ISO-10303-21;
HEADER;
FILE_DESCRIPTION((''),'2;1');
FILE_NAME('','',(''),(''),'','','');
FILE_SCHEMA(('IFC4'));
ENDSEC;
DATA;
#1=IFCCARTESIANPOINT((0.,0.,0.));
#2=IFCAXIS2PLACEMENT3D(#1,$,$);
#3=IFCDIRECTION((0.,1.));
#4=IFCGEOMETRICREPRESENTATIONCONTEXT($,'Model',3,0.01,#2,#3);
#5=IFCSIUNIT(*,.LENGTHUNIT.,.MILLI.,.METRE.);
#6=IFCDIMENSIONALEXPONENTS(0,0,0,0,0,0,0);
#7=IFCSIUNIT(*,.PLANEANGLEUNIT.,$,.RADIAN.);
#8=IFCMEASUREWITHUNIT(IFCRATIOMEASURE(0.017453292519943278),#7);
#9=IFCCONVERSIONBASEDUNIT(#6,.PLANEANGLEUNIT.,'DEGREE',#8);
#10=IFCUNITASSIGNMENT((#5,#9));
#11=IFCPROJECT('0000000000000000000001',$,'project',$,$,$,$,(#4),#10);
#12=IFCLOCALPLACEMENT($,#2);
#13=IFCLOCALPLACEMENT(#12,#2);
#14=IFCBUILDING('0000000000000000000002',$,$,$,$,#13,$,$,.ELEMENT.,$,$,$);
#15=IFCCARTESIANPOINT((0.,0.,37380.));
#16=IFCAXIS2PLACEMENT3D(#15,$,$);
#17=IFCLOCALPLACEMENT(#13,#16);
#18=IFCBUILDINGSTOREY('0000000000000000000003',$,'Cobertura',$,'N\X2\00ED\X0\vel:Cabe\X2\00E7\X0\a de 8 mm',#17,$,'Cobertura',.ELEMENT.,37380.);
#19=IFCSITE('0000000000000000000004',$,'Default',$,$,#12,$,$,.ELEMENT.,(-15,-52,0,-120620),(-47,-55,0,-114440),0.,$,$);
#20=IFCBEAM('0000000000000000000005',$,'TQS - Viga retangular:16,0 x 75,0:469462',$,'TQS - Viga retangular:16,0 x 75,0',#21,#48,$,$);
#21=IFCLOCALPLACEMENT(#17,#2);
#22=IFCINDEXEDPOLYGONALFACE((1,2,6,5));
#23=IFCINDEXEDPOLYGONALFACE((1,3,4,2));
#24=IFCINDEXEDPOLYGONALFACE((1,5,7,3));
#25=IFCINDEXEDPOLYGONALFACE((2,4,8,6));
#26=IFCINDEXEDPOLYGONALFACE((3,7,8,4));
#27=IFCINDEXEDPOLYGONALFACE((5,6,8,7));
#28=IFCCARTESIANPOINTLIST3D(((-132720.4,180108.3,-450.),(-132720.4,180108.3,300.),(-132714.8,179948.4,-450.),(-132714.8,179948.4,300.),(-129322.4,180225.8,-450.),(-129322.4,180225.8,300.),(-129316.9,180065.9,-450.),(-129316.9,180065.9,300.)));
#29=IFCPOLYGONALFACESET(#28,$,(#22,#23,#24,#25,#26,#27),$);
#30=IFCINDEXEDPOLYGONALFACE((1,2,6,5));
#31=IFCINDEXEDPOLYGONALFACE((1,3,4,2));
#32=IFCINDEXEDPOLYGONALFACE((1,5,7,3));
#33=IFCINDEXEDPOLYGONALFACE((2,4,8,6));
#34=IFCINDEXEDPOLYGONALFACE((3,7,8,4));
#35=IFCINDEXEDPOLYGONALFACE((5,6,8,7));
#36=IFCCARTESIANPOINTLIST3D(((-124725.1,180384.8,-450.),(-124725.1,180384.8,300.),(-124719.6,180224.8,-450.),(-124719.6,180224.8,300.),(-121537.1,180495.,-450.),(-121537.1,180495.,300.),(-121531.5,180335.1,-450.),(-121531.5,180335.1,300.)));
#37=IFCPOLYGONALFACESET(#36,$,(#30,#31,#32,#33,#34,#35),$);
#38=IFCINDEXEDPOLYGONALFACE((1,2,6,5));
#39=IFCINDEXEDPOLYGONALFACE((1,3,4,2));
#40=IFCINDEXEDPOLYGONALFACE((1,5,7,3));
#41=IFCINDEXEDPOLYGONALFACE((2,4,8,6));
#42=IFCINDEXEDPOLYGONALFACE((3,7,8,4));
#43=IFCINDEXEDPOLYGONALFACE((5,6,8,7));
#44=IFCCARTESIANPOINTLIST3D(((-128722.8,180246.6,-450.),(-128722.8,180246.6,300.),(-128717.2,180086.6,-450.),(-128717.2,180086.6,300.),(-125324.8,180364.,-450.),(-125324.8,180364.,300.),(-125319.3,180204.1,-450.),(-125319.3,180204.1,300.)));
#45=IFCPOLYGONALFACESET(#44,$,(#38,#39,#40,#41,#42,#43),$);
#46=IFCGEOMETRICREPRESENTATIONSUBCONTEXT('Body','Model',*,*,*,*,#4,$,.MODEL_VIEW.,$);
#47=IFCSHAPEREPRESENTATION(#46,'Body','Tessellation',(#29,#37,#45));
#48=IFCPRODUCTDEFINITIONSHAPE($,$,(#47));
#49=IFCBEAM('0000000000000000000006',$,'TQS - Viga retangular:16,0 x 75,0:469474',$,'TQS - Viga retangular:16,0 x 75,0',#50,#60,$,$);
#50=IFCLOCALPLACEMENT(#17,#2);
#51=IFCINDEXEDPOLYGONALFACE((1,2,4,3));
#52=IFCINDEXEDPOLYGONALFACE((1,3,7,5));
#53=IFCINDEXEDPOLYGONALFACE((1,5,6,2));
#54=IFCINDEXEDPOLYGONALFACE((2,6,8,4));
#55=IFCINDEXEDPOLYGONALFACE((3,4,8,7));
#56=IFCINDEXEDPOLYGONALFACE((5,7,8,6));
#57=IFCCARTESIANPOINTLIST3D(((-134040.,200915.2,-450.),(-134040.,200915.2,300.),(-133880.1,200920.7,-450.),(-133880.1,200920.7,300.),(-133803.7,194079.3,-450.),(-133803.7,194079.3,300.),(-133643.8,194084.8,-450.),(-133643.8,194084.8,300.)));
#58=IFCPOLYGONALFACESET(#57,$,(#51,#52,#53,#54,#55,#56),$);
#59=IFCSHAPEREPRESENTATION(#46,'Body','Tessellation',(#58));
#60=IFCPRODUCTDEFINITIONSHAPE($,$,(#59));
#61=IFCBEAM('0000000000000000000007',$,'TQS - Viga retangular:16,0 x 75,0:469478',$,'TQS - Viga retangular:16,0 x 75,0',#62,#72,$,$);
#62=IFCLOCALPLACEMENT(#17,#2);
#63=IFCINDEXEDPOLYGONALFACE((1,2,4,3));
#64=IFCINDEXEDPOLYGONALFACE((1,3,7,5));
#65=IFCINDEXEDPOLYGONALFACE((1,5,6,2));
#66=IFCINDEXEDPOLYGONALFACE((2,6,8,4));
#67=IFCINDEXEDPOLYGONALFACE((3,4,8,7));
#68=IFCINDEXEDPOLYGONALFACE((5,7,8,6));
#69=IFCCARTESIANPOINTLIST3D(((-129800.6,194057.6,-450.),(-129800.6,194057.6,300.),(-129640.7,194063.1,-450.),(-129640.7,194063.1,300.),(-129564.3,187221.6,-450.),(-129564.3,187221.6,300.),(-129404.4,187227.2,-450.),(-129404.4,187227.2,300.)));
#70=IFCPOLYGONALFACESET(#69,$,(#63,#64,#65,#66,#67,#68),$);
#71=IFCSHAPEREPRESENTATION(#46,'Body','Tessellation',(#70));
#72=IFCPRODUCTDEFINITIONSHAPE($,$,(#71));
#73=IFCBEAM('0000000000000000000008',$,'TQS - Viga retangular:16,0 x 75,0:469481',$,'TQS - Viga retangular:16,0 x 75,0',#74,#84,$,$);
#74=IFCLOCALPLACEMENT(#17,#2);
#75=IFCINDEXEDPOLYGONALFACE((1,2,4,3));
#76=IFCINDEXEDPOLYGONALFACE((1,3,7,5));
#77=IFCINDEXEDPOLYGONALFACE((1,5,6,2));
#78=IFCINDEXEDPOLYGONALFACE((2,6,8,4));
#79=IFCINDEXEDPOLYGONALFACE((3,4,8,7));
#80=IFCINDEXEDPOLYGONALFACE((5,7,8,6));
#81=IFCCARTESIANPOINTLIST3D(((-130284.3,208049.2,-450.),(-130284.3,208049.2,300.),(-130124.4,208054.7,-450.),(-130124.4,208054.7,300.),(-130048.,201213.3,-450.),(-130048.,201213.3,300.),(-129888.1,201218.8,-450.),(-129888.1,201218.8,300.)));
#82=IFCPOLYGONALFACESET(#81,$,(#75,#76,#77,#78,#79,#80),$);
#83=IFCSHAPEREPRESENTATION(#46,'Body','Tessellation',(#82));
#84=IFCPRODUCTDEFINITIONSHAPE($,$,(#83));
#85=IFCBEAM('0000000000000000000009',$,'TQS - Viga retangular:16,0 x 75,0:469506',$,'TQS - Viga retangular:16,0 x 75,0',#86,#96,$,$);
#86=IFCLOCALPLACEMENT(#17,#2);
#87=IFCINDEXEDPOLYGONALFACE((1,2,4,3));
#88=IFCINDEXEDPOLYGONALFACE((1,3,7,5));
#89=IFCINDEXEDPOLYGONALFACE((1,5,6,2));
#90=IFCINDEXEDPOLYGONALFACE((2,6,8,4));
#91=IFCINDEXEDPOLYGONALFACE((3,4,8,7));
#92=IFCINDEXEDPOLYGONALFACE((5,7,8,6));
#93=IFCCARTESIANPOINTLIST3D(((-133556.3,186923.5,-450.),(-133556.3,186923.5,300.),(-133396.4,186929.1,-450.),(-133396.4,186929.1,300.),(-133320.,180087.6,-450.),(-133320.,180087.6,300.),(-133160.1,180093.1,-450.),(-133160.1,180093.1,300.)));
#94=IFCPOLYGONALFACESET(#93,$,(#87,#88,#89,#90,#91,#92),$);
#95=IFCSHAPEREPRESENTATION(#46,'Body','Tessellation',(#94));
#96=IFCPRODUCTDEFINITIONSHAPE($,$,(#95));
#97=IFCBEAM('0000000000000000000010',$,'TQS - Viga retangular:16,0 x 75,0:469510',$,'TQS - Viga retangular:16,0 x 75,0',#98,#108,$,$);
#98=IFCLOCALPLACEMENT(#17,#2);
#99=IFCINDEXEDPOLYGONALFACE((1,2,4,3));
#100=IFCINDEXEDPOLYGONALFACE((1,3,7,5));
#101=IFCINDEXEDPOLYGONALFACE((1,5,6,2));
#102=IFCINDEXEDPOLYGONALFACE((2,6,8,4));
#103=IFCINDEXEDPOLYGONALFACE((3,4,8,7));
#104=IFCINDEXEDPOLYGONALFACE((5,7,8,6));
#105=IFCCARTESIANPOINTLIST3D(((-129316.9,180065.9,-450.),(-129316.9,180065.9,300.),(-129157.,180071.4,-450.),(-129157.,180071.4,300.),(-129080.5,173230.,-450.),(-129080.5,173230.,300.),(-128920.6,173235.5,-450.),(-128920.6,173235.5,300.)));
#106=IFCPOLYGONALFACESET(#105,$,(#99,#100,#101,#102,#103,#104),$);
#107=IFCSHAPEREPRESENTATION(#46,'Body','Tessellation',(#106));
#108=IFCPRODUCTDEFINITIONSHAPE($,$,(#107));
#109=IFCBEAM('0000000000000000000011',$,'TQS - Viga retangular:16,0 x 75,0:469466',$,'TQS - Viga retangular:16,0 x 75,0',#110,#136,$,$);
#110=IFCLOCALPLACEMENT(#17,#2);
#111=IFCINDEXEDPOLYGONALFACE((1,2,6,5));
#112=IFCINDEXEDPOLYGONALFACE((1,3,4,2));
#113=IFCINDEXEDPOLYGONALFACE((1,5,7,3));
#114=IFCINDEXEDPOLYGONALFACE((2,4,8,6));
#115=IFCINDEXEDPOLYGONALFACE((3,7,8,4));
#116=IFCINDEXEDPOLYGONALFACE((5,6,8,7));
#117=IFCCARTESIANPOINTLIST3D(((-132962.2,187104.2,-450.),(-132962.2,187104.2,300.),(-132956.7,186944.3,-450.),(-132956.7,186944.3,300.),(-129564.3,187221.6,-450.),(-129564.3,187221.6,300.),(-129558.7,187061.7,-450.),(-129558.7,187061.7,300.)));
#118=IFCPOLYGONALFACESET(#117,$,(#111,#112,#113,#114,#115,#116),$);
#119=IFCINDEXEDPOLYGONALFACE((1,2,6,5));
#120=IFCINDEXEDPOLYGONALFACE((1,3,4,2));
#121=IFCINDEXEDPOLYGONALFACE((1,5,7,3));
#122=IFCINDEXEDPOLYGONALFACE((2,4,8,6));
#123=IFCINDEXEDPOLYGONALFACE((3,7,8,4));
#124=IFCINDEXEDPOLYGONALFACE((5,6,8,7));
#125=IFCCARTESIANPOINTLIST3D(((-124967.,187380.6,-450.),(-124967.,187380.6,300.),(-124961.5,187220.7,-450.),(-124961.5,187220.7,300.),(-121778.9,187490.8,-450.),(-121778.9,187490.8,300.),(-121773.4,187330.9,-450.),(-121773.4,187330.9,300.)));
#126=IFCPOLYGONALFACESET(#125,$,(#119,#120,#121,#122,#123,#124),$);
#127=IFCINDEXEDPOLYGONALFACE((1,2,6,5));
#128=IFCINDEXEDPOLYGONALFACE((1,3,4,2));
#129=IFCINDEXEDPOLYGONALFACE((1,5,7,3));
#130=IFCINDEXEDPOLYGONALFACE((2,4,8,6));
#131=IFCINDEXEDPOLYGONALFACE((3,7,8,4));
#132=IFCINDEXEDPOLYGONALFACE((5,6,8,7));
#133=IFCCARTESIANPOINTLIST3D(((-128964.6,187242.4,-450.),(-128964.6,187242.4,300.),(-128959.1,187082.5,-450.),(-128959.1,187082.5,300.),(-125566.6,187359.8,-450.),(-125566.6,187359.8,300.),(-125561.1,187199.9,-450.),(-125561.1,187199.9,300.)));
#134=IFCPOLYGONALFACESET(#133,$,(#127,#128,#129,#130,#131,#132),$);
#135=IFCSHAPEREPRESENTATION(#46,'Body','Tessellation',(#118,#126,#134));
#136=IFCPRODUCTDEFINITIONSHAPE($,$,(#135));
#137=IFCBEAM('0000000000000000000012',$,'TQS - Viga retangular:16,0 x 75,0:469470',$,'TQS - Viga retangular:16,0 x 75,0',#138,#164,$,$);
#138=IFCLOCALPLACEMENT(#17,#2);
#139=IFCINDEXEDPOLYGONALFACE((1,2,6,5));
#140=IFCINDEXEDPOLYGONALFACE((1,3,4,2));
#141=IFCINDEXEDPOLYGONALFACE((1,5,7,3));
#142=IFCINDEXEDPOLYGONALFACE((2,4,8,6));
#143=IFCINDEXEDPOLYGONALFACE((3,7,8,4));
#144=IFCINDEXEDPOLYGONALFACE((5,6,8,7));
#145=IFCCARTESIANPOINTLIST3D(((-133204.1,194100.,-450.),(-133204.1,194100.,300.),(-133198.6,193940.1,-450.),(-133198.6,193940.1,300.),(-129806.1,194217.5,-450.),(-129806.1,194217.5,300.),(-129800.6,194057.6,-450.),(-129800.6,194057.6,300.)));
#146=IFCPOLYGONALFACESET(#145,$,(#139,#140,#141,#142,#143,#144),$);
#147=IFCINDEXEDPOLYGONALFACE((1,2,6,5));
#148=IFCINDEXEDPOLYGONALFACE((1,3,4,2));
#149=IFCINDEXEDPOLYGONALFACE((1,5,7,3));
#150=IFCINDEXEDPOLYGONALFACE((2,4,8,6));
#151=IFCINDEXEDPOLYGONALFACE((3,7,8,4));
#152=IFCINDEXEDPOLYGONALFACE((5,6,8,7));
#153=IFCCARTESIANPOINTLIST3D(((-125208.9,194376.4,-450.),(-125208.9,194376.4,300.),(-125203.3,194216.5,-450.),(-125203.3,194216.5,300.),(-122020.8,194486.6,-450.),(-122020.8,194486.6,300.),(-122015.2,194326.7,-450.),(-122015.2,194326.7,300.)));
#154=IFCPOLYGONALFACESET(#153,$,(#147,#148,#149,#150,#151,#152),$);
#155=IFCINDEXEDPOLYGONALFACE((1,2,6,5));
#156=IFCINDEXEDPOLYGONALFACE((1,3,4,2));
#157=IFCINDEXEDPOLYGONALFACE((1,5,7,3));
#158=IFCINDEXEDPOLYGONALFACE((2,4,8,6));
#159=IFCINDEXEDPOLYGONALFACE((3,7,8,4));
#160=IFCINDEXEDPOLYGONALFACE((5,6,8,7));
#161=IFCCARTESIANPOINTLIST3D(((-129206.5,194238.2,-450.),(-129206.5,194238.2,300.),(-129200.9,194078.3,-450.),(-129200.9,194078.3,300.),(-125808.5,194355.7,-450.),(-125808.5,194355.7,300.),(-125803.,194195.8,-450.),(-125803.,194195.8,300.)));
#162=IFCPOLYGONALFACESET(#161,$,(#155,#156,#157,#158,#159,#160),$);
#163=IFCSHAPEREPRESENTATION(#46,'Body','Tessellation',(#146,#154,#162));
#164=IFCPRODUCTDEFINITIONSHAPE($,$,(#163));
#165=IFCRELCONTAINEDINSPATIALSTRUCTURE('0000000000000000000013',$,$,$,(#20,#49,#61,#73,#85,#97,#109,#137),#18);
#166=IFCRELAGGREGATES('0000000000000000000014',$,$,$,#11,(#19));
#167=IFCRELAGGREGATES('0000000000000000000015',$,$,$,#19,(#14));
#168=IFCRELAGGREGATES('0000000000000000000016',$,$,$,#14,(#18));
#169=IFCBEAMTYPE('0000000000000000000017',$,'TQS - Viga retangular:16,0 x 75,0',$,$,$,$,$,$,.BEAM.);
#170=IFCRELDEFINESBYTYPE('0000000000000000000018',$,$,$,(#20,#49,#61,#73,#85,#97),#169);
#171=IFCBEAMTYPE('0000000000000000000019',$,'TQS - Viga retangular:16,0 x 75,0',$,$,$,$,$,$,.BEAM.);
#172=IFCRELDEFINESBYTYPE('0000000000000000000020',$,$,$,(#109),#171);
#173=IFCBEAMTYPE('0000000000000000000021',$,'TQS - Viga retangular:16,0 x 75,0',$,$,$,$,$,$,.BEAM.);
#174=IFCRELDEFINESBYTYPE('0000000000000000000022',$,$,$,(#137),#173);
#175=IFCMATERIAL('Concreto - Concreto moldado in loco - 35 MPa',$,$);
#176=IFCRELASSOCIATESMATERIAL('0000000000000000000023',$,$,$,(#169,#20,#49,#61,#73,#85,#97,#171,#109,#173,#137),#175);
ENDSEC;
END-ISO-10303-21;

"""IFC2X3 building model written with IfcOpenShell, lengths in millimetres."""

from ifc_helpers import new_model, entity, si_unit, converted_unit, direction, frame, frame_2d, origin, place, context, subcontext, project, spatial, rectangle, extrude, source, transform, mapped, material, type_object, type_shapes, element, save


model = new_model("IFC2X3")

# Units and contexts
model_context = context("Model", 3, precision=0.01, world=origin(), true_north=direction((0.0, 1.0)))
body_context = subcontext(model_context, "Body", "Model", "MODEL_VIEW")
ifc_project = project(units=[si_unit("LENGTHUNIT", "METRE", prefix="MILLI"), converted_unit("PLANEANGLEUNIT", "DEGREE", entity("IfcRatioMeasure", 0.017453292519943278), si_unit("PLANEANGLEUNIT", "RADIAN"), dimensions=[0, 0, 0, 0, 0, 0, 0])], contexts=[model_context])

# Site, building, storey
site_placement = place(None, origin())
site = spatial("IfcSite", under=ifc_project, at=site_placement, Name="Default", CompositionType="ELEMENT", RefLatitude=(-15, -52, 0, -120620), RefLongitude=(-47, -55, 0, -114440), RefElevation=0.0)
building_placement = place(site_placement, origin())
building = spatial("IfcBuilding", under=site, at=building_placement, CompositionType="ELEMENT")
storey_placement = place(building_placement, frame((0.0, 0.0, 37380.0)))
storey = spatial("IfcBuildingStorey", under=building, at=storey_placement, Name="Cobertura", ObjectType="Nível:Cabeça de 8 mm", LongName="Cobertura", CompositionType="ELEMENT", Elevation=37380.0)

# Beams
ifc_material = material(Name="Concreto - Concreto moldado in loco - 35 MPa")
beam_type_1 = type_object("IfcBeamType", Name="TQS - Viga retangular:16,0 x 75,0", PredefinedType="BEAM", material=ifc_material)
shared_shape_1 = source(origin(), body_context, "Body", "SweptSolid", [
    extrude(rectangle(XDim=750.0, YDim=160.0, at=frame_2d((0.0, 0.0), x_axis=(1.0, 0.0))), frame((-129319.6, 180145.9, 37305.0), z_axis=(-0.999403, -0.034551, 0.0), x_axis=(0.0, 0.0, -1.0)), (0.0, 0.0, 1.0), 3400.0),
    extrude(rectangle(XDim=750.0, YDim=160.0, at=frame_2d((0.0, 0.0), x_axis=(1.0, 0.0))), frame((-121534.3, 180415.0, 37305.0), z_axis=(-0.999403, -0.034551, 0.0), x_axis=(0.0, 0.0, -1.0)), (0.0, 0.0, 1.0), 3190.0),
    extrude(rectangle(XDim=750.0, YDim=160.0, at=frame_2d((0.0, 0.0), x_axis=(1.0, 0.0))), frame((-125322.0, 180284.1, 37305.0), z_axis=(-0.999403, -0.034551, 0.0), x_axis=(0.0, 0.0, -1.0)), (0.0, 0.0, 1.0), 3400.0),
])
type_shapes(beam_type_1, [shared_shape_1])
beam_1_placement = place(storey_placement, frame((0.0, 0.0, -37380.0)))
element("IfcBeam", 1, at=beam_1_placement, inside=storey, type_object=beam_type_1, material=ifc_material, Name="TQS - Viga retangular:16,0 x 75,0:469462", ObjectType="TQS - Viga retangular:16,0 x 75,0", context=body_context, shape_type="MappedRepresentation", body=[
    mapped(shared_shape_1, transform((0.0, 0.0, 0.0), scale=1.0)),
])
beam_2_placement = place(storey_placement, frame((-133721.0, 194002.1, 300.0), z_axis=(0.0, 0.0, 1.0), x_axis=(-0.034551, 0.999403, 0.0)))
element("IfcBeam", 2, at=beam_2_placement, inside=storey, type_object=beam_type_1, material=ifc_material, Name="TQS - Viga retangular:16,0 x 75,0:469474", ObjectType="TQS - Viga retangular:16,0 x 75,0", context=body_context, shape_type="SweptSolid", body=[
    extrude(rectangle(XDim=750.0, YDim=160.0, at=frame_2d((0.0, 0.0), x_axis=(1.0, 0.0))), frame((80.0, 0.0, -375.0), z_axis=(1.0, 0.0, 0.0), x_axis=(0.0, 0.0, -1.0)), (0.0, 0.0, 1.0), 6840.0),
])
beam_3_placement = place(storey_placement, frame((-129481.5, 187144.5, 300.0), z_axis=(0.0, 0.0, 1.0), x_axis=(-0.034551, 0.999403, 0.0)))
element("IfcBeam", 3, at=beam_3_placement, inside=storey, type_object=beam_type_1, material=ifc_material, Name="TQS - Viga retangular:16,0 x 75,0:469478", ObjectType="TQS - Viga retangular:16,0 x 75,0", context=body_context, shape_type="SweptSolid", body=[
    extrude(rectangle(XDim=750.0, YDim=160.0, at=frame_2d((0.0, 0.0), x_axis=(1.0, 0.0))), frame((80.0, 0.0, -375.0), z_axis=(1.0, 0.0, 0.0), x_axis=(0.0, 0.0, -1.0)), (0.0, 0.0, 1.0), 6840.0),
])
beam_4_placement = place(storey_placement, frame((-129965.2, 201136.1, 300.0), z_axis=(0.0, 0.0, 1.0), x_axis=(-0.034551, 0.999403, 0.0)))
element("IfcBeam", 4, at=beam_4_placement, inside=storey, type_object=beam_type_1, material=ifc_material, Name="TQS - Viga retangular:16,0 x 75,0:469481", ObjectType="TQS - Viga retangular:16,0 x 75,0", context=body_context, shape_type="SweptSolid", body=[
    extrude(rectangle(XDim=750.0, YDim=160.0, at=frame_2d((0.0, 0.0), x_axis=(1.0, 0.0))), frame((80.0, 0.0, -375.0), z_axis=(1.0, 0.0, 0.0), x_axis=(0.0, 0.0, -1.0)), (0.0, 0.0, 1.0), 6840.0),
])
beam_5_placement = place(storey_placement, frame((-133237.3, 180010.4, 300.0), z_axis=(0.0, 0.0, 1.0), x_axis=(-0.034551, 0.999403, 0.0)))
element("IfcBeam", 5, at=beam_5_placement, inside=storey, type_object=beam_type_1, material=ifc_material, Name="TQS - Viga retangular:16,0 x 75,0:469506", ObjectType="TQS - Viga retangular:16,0 x 75,0", context=body_context, shape_type="SweptSolid", body=[
    extrude(rectangle(XDim=750.0, YDim=160.0, at=frame_2d((0.0, 0.0), x_axis=(1.0, 0.0))), frame((80.0, 0.0, -375.0), z_axis=(1.0, 0.0, 0.0), x_axis=(0.0, 0.0, -1.0)), (0.0, 0.0, 1.0), 6840.0),
])
beam_6_placement = place(storey_placement, frame((-128997.8, 173152.8, 300.0), z_axis=(0.0, 0.0, 1.0), x_axis=(-0.034551, 0.999403, 0.0)))
element("IfcBeam", 6, at=beam_6_placement, inside=storey, type_object=beam_type_1, material=ifc_material, Name="TQS - Viga retangular:16,0 x 75,0:469510", ObjectType="TQS - Viga retangular:16,0 x 75,0", context=body_context, shape_type="SweptSolid", body=[
    extrude(rectangle(XDim=750.0, YDim=160.0, at=frame_2d((0.0, 0.0), x_axis=(1.0, 0.0))), frame((80.0, 0.0, -375.0), z_axis=(1.0, 0.0, 0.0), x_axis=(0.0, 0.0, -1.0)), (0.0, 0.0, 1.0), 6840.0),
])
beam_type_2 = type_object("IfcBeamType", Name="TQS - Viga retangular:16,0 x 75,0", PredefinedType="BEAM", material=ifc_material)
shared_shape_2 = source(origin(), body_context, "Body", "SweptSolid", [
    extrude(rectangle(XDim=750.0, YDim=160.0, at=frame_2d((0.0, 0.0), x_axis=(1.0, 0.0))), frame((-129561.5, 187141.7, 37305.0), z_axis=(-0.999403, -0.034551, 0.0), x_axis=(0.0, 0.0, -1.0)), (0.0, 0.0, 1.0), 3400.0),
    extrude(rectangle(XDim=750.0, YDim=160.0, at=frame_2d((0.0, 0.0), x_axis=(1.0, 0.0))), frame((-121776.1, 187410.8, 37305.0), z_axis=(-0.999403, -0.034551, 0.0), x_axis=(0.0, 0.0, -1.0)), (0.0, 0.0, 1.0), 3190.0),
    extrude(rectangle(XDim=750.0, YDim=160.0, at=frame_2d((0.0, 0.0), x_axis=(1.0, 0.0))), frame((-125563.9, 187279.9, 37305.0), z_axis=(-0.999403, -0.034551, 0.0), x_axis=(0.0, 0.0, -1.0)), (0.0, 0.0, 1.0), 3400.0),
])
type_shapes(beam_type_2, [shared_shape_2])
beam_7_placement = place(storey_placement, frame((0.0, 0.0, -37380.0)))
element("IfcBeam", 7, at=beam_7_placement, inside=storey, type_object=beam_type_2, material=ifc_material, Name="TQS - Viga retangular:16,0 x 75,0:469466", ObjectType="TQS - Viga retangular:16,0 x 75,0", context=body_context, shape_type="MappedRepresentation", body=[
    mapped(shared_shape_2, transform((0.0, 0.0, 0.0), scale=1.0)),
])
beam_type_3 = type_object("IfcBeamType", Name="TQS - Viga retangular:16,0 x 75,0", PredefinedType="BEAM", material=ifc_material)
shared_shape_3 = source(origin(), body_context, "Body", "SweptSolid", [
    extrude(rectangle(XDim=750.0, YDim=160.0, at=frame_2d((0.0, 0.0), x_axis=(1.0, 0.0))), frame((-129803.3, 194137.5, 37305.0), z_axis=(-0.999403, -0.034551, 0.0), x_axis=(0.0, 0.0, -1.0)), (0.0, 0.0, 1.0), 3400.0),
    extrude(rectangle(XDim=750.0, YDim=160.0, at=frame_2d((0.0, 0.0), x_axis=(1.0, 0.0))), frame((-122018.0, 194406.7, 37305.0), z_axis=(-0.999403, -0.034551, 0.0), x_axis=(0.0, 0.0, -1.0)), (0.0, 0.0, 1.0), 3190.0),
    extrude(rectangle(XDim=750.0, YDim=160.0, at=frame_2d((0.0, 0.0), x_axis=(1.0, 0.0))), frame((-125805.7, 194275.7, 37305.0), z_axis=(-0.999403, -0.034551, 0.0), x_axis=(0.0, 0.0, -1.0)), (0.0, 0.0, 1.0), 3400.0),
])
type_shapes(beam_type_3, [shared_shape_3])
beam_8_placement = place(storey_placement, frame((0.0, 0.0, -37380.0)))
element("IfcBeam", 8, at=beam_8_placement, inside=storey, type_object=beam_type_3, material=ifc_material, Name="TQS - Viga retangular:16,0 x 75,0:469470", ObjectType="TQS - Viga retangular:16,0 x 75,0", context=body_context, shape_type="MappedRepresentation", body=[
    mapped(shared_shape_3, transform((0.0, 0.0, 0.0), scale=1.0)),
])

save(model, "model.ifc")
